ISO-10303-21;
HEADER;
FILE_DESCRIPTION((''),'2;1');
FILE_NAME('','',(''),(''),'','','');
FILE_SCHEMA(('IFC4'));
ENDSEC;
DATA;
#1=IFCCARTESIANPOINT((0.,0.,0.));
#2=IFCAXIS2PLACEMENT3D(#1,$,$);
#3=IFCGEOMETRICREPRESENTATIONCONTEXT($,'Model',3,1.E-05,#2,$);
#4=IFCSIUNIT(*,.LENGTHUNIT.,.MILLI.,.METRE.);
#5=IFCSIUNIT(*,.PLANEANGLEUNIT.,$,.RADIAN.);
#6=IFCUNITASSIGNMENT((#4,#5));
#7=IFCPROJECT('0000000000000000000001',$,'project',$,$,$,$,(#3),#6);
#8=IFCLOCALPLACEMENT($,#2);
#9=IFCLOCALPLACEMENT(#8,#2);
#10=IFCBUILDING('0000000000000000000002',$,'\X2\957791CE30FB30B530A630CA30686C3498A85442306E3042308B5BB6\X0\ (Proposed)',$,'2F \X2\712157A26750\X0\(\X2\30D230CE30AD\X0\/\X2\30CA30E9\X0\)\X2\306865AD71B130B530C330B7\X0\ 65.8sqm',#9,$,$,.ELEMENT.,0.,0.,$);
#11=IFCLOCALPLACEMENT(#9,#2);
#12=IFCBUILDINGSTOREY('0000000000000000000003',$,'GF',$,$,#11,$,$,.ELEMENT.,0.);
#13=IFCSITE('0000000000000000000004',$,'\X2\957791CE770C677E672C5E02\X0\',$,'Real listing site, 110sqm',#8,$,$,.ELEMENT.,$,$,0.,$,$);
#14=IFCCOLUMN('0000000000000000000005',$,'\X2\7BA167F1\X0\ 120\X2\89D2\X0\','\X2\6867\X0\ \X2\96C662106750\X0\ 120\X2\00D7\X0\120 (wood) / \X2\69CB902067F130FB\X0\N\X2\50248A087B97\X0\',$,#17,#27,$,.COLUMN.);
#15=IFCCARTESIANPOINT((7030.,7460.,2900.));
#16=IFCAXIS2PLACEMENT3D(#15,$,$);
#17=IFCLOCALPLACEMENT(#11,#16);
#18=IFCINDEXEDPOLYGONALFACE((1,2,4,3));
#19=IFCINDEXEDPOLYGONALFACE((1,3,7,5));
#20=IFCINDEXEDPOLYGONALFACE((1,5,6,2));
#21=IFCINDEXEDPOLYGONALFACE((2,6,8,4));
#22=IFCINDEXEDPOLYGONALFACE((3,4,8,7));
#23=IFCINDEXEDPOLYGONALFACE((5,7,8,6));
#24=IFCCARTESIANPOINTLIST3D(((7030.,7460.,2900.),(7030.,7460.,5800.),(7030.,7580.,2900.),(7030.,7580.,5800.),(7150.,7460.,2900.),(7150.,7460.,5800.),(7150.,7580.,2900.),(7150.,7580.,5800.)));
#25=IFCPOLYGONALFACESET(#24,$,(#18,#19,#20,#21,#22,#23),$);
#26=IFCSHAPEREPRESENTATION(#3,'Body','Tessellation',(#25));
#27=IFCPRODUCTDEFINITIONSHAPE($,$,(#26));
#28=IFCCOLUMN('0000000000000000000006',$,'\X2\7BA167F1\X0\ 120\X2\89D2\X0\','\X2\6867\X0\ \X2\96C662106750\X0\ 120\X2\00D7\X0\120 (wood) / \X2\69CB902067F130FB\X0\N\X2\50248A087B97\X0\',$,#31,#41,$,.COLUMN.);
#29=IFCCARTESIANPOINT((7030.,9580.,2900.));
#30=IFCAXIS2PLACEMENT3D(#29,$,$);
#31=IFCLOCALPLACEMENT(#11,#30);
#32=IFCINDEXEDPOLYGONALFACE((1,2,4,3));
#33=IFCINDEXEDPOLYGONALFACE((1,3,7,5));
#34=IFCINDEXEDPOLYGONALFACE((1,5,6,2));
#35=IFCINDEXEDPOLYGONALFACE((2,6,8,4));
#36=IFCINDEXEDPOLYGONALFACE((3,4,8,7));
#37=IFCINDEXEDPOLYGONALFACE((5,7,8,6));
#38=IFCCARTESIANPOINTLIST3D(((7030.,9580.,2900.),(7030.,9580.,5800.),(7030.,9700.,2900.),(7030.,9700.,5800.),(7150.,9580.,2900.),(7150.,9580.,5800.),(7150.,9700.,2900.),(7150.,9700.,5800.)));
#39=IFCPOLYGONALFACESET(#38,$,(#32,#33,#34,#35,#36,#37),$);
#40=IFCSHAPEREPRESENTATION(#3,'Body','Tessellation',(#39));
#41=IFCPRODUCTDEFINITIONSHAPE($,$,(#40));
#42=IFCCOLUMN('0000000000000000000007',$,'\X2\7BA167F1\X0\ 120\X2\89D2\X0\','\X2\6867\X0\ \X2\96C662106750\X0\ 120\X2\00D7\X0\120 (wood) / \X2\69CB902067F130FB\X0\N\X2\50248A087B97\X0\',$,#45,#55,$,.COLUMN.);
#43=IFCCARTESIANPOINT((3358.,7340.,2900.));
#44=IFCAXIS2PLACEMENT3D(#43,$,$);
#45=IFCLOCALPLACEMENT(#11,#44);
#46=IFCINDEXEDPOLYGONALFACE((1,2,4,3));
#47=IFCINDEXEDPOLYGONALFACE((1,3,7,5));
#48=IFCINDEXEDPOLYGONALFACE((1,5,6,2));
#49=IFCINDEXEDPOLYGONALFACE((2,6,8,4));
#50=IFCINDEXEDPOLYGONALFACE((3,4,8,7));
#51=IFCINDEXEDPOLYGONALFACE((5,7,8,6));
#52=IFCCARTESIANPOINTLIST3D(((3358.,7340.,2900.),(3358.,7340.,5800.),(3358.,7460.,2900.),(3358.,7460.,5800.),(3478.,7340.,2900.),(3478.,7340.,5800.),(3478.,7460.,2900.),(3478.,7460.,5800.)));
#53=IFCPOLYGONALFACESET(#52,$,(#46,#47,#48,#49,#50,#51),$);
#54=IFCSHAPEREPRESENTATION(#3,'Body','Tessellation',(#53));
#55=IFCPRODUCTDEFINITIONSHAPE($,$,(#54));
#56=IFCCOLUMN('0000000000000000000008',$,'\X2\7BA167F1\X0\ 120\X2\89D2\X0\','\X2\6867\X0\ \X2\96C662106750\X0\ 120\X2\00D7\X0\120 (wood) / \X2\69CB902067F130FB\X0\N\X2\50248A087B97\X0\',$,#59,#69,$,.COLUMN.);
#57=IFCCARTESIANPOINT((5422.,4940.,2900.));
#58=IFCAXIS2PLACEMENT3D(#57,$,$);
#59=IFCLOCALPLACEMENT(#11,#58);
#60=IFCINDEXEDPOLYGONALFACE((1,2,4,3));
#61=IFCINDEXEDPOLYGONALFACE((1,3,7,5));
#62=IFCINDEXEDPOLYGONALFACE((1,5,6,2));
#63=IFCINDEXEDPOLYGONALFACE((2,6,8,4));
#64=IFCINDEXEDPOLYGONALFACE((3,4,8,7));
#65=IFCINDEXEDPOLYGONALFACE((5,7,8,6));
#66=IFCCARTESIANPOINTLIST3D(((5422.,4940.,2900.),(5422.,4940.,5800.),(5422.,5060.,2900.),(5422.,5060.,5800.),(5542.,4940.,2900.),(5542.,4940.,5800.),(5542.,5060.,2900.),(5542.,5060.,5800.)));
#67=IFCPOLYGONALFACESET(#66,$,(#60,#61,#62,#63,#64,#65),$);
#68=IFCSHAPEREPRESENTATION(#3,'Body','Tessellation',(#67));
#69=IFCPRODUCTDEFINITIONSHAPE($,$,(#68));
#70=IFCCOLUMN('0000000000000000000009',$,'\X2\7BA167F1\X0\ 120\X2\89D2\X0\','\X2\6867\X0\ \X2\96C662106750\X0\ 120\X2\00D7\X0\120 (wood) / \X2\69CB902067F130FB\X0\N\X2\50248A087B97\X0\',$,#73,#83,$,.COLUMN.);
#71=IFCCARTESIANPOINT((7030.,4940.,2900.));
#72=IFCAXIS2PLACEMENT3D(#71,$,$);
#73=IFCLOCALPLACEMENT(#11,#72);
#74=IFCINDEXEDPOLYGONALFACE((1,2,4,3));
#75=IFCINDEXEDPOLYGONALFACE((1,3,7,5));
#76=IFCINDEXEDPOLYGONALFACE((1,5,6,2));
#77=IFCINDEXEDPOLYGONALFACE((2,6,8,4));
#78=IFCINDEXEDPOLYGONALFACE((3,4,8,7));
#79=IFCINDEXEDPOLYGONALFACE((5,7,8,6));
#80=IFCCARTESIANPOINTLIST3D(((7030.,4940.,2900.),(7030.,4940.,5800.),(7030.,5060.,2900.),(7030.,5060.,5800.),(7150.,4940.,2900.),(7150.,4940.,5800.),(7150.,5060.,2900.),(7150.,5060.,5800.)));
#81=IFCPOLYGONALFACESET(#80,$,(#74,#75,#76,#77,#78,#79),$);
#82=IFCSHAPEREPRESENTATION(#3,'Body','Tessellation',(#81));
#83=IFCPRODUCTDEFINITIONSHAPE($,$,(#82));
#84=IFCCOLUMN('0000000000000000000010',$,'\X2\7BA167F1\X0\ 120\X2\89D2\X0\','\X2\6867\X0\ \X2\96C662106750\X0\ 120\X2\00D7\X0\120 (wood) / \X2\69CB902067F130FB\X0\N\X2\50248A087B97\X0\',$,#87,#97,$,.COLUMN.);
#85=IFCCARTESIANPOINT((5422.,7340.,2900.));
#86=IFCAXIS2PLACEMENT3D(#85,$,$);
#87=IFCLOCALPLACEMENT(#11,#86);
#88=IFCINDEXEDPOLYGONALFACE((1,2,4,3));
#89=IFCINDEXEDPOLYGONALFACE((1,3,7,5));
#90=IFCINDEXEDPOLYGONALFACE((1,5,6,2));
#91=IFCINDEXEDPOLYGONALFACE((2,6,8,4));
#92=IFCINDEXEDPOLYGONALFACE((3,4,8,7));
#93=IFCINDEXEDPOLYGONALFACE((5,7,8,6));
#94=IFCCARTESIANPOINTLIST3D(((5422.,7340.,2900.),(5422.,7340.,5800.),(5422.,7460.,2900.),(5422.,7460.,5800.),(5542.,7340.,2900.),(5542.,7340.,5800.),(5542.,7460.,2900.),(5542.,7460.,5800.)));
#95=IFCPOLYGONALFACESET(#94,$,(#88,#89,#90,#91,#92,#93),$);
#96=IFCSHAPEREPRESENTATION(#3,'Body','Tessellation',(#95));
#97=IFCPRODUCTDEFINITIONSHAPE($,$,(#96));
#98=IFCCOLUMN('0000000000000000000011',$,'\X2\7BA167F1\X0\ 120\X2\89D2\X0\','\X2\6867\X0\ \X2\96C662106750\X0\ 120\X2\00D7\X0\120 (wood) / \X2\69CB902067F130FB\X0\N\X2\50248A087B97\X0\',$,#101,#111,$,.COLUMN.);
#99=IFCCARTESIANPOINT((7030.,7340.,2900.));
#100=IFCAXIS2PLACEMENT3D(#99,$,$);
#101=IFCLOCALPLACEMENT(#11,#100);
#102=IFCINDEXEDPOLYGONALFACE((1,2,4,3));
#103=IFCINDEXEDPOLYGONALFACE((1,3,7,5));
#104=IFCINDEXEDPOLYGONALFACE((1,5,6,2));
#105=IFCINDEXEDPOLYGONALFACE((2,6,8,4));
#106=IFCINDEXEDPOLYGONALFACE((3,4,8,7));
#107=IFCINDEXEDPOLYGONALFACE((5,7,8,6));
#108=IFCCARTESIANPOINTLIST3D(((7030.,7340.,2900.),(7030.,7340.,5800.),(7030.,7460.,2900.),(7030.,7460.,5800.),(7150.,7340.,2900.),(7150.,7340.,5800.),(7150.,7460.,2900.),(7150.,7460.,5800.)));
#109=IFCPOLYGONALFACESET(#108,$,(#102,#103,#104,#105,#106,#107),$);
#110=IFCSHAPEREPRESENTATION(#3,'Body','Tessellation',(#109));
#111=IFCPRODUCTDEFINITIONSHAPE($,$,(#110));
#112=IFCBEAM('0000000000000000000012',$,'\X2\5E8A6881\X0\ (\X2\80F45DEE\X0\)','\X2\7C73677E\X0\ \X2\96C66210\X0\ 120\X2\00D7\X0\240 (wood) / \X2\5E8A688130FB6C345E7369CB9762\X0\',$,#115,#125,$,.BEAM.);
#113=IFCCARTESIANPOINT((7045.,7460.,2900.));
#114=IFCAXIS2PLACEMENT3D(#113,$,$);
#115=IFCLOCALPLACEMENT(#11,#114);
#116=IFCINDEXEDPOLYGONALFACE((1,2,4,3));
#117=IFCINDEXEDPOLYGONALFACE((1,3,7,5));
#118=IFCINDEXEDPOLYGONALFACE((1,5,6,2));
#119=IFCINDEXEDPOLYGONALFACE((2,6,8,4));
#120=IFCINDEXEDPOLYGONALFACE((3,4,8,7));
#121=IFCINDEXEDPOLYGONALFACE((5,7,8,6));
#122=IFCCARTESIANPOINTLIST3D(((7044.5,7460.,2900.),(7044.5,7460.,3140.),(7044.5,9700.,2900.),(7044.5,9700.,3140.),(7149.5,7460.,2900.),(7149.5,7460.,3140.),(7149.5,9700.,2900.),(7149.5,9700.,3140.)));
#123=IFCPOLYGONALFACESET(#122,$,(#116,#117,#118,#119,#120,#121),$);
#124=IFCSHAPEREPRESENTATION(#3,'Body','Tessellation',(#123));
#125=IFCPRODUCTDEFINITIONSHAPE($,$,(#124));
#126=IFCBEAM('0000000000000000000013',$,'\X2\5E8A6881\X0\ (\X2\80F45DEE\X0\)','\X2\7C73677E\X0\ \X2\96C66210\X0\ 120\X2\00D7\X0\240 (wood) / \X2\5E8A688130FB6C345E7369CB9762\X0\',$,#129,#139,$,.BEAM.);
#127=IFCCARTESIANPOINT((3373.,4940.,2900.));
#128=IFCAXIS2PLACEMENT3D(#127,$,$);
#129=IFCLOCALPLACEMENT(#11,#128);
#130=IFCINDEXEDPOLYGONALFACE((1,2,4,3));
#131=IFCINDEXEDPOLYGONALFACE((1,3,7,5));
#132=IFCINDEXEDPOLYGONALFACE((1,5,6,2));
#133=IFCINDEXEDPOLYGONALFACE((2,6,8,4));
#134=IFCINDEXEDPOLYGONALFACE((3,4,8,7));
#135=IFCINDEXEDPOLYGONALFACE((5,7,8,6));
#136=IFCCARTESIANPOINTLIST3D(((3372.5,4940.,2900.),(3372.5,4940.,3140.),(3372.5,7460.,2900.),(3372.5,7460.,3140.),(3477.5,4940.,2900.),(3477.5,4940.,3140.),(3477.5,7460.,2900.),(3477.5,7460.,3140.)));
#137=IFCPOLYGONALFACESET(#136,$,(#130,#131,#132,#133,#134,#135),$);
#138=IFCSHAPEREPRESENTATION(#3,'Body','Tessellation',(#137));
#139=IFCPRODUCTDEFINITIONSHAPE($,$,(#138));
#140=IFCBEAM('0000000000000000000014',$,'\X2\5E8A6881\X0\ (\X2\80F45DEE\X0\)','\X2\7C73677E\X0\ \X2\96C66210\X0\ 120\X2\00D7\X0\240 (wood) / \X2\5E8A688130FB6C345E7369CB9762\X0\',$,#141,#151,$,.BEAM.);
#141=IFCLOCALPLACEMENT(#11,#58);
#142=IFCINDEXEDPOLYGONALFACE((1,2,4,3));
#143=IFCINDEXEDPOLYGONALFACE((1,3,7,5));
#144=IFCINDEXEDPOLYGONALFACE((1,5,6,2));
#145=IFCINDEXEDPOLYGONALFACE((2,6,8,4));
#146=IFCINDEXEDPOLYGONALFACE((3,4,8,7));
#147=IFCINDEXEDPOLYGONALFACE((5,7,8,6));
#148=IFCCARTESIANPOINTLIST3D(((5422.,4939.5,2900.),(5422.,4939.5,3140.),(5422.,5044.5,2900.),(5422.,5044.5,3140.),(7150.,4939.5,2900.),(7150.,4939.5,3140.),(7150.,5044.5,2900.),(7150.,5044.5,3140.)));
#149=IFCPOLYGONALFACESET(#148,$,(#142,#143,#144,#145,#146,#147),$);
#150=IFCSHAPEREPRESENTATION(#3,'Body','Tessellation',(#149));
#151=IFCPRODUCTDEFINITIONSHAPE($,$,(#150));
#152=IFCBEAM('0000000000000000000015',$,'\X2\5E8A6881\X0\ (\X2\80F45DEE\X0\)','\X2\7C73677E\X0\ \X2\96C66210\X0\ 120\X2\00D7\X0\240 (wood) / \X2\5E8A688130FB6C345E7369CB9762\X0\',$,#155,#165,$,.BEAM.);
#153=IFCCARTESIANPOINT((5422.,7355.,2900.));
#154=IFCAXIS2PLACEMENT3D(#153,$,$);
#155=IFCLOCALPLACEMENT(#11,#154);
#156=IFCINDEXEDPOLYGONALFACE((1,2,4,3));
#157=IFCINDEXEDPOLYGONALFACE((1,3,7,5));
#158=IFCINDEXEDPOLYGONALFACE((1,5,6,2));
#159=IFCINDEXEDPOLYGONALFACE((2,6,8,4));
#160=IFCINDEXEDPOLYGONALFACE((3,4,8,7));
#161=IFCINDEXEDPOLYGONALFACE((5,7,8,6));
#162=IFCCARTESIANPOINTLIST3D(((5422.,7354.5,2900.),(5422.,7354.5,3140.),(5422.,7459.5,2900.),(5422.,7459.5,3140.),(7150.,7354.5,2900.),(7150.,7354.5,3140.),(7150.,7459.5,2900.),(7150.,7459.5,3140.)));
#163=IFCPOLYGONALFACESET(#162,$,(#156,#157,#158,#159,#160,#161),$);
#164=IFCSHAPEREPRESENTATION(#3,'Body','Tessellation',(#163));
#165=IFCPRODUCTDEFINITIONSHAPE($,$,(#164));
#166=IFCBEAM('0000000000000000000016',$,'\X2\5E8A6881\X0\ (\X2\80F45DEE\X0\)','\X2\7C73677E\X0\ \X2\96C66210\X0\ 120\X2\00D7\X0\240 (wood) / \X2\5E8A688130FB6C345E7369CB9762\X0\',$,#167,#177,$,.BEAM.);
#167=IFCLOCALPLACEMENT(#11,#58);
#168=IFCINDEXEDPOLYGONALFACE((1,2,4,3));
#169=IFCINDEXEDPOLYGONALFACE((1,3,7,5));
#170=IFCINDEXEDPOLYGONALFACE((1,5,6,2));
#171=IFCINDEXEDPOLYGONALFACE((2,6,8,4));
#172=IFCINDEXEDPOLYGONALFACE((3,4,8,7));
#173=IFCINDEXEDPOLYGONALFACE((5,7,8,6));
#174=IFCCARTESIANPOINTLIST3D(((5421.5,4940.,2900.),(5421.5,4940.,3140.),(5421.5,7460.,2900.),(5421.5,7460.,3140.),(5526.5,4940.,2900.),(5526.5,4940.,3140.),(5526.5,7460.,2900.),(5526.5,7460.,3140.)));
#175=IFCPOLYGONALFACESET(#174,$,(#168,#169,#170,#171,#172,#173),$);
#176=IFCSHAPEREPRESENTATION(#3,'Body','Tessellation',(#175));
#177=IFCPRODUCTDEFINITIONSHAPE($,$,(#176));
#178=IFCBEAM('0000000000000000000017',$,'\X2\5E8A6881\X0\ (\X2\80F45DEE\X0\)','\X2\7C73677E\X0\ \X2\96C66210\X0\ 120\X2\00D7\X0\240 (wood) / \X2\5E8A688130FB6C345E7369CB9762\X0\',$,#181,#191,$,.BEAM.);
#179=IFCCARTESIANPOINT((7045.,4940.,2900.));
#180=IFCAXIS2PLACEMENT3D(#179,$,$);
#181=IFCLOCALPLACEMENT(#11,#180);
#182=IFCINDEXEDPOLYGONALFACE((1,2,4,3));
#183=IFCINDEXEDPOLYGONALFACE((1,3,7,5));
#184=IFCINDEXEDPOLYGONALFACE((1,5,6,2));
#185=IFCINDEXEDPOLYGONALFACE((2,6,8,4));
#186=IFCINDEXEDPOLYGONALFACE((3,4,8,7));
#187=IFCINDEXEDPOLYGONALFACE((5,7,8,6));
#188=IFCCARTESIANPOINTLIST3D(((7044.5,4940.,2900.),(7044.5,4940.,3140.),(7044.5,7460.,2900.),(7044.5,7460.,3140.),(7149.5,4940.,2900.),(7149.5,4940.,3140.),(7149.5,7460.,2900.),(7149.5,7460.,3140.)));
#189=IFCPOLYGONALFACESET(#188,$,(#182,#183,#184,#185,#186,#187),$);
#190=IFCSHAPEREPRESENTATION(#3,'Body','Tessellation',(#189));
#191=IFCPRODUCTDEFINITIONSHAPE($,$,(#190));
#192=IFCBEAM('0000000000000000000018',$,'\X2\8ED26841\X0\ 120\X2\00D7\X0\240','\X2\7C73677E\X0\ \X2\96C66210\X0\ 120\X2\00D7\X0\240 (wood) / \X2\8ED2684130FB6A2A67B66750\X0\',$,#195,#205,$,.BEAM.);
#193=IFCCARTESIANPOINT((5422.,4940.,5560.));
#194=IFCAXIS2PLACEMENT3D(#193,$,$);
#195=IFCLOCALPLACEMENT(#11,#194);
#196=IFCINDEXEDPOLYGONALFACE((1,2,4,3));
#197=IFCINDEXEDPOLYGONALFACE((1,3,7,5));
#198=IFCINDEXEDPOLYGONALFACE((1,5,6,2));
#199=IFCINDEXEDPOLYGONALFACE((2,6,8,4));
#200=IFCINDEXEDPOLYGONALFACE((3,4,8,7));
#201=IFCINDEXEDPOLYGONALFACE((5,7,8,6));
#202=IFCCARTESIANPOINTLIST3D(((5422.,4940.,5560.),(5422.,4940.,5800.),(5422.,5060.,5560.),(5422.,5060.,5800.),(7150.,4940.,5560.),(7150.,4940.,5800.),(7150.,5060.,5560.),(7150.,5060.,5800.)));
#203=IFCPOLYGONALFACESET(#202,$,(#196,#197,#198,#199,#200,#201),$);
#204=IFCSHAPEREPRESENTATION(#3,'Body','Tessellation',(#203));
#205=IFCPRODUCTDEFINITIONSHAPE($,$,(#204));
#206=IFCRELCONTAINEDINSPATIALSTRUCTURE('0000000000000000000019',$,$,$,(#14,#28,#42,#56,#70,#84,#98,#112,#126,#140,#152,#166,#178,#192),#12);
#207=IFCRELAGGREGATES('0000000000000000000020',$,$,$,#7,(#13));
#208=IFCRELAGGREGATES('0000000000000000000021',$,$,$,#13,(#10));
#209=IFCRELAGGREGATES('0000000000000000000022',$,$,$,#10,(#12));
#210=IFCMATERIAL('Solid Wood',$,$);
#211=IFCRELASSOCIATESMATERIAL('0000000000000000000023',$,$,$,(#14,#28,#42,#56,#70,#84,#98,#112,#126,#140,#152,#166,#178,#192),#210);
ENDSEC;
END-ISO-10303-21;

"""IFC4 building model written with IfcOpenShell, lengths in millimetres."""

from ifc_helpers import new_model, si_unit, frame, frame_2d, origin, place, context, project, spatial, rectangle, extrude, material, element, save


model = new_model("IFC4")

# Units and contexts
model_context = context("Model", 3, precision=1e-05, world=origin())
ifc_project = project(units=[si_unit("LENGTHUNIT", "METRE", prefix="MILLI"), si_unit("PLANEANGLEUNIT", "RADIAN")], contexts=[model_context])

# Site, building, storey
site_placement = place(None, origin())
site = spatial("IfcSite", under=ifc_project, at=site_placement, Name="長野県松本市", ObjectType="Real listing site, 110sqm", CompositionType="ELEMENT", RefElevation=0.0)
building_placement = place(site_placement, origin())
building = spatial("IfcBuilding", under=site, at=building_placement, Name="長野・サウナと水風呂のある家 (Proposed)", ObjectType="2F 無垢材(ヒノキ/ナラ)と断熱サッシ 65.8sqm", CompositionType="ELEMENT", ElevationOfRefHeight=0.0, ElevationOfTerrain=0.0)
storey_placement = place(building_placement, origin())
storey = spatial("IfcBuildingStorey", under=building, at=storey_placement, Name="GF", CompositionType="ELEMENT", Elevation=0.0)

# Columns
ifc_material_1 = material(Name="Solid Wood")
column_1_placement = place(storey_placement, frame((7030.0, 7460.0, 2900.0)))
element("IfcColumn", 1, at=column_1_placement, inside=storey, material=ifc_material_1, Name="管柱 120角", Description="桧 集成材 120×120 (wood) / 構造柱・N値計算", PredefinedType="COLUMN", context=model_context, shape_type="SweptSolid", body=[
    extrude(rectangle(XDim=120.0, YDim=120.0, at=frame_2d((60.0, 60.0))), frame((7030.0, 7460.0, 2900.0)), (0.0, 0.0, 1.0), 2900.0),
])
column_2_placement = place(storey_placement, frame((7030.0, 9580.0, 2900.0)))
element("IfcColumn", 2, at=column_2_placement, inside=storey, material=ifc_material_1, Name="管柱 120角", Description="桧 集成材 120×120 (wood) / 構造柱・N値計算", PredefinedType="COLUMN", context=model_context, shape_type="SweptSolid", body=[
    extrude(rectangle(XDim=120.0, YDim=120.0, at=frame_2d((60.0, 60.0))), frame((7030.0, 9580.0, 2900.0)), (0.0, 0.0, 1.0), 2900.0),
])
column_3_placement = place(storey_placement, frame((3358.0, 7340.0, 2900.0)))
element("IfcColumn", 3, at=column_3_placement, inside=storey, material=ifc_material_1, Name="管柱 120角", Description="桧 集成材 120×120 (wood) / 構造柱・N値計算", PredefinedType="COLUMN", context=model_context, shape_type="SweptSolid", body=[
    extrude(rectangle(XDim=120.0, YDim=120.0, at=frame_2d((60.0, 60.0))), frame((3358.0, 7340.0, 2900.0)), (0.0, 0.0, 1.0), 2900.0),
])
column_4_placement = place(storey_placement, frame((5422.0, 4940.0, 2900.0)))
element("IfcColumn", 4, at=column_4_placement, inside=storey, material=ifc_material_1, Name="管柱 120角", Description="桧 集成材 120×120 (wood) / 構造柱・N値計算", PredefinedType="COLUMN", context=model_context, shape_type="SweptSolid", body=[
    extrude(rectangle(XDim=120.0, YDim=120.0, at=frame_2d((60.0, 60.0))), frame((5422.0, 4940.0, 2900.0)), (0.0, 0.0, 1.0), 2900.0),
])
column_5_placement = place(storey_placement, frame((7030.0, 4940.0, 2900.0)))
element("IfcColumn", 5, at=column_5_placement, inside=storey, material=ifc_material_1, Name="管柱 120角", Description="桧 集成材 120×120 (wood) / 構造柱・N値計算", PredefinedType="COLUMN", context=model_context, shape_type="SweptSolid", body=[
    extrude(rectangle(XDim=120.0, YDim=120.0, at=frame_2d((60.0, 60.0))), frame((7030.0, 4940.0, 2900.0)), (0.0, 0.0, 1.0), 2900.0),
])
column_6_placement = place(storey_placement, frame((5422.0, 7340.0, 2900.0)))
element("IfcColumn", 6, at=column_6_placement, inside=storey, material=ifc_material_1, Name="管柱 120角", Description="桧 集成材 120×120 (wood) / 構造柱・N値計算", PredefinedType="COLUMN", context=model_context, shape_type="SweptSolid", body=[
    extrude(rectangle(XDim=120.0, YDim=120.0, at=frame_2d((60.0, 60.0))), frame((5422.0, 7340.0, 2900.0)), (0.0, 0.0, 1.0), 2900.0),
])
column_7_placement = place(storey_placement, frame((7030.0, 7340.0, 2900.0)))
element("IfcColumn", 7, at=column_7_placement, inside=storey, material=ifc_material_1, Name="管柱 120角", Description="桧 集成材 120×120 (wood) / 構造柱・N値計算", PredefinedType="COLUMN", context=model_context, shape_type="SweptSolid", body=[
    extrude(rectangle(XDim=120.0, YDim=120.0, at=frame_2d((60.0, 60.0))), frame((7030.0, 7340.0, 2900.0)), (0.0, 0.0, 1.0), 2900.0),
])

# Beams
beam_1_placement = place(storey_placement, frame((7045.0, 7460.0, 2900.0)))
element("IfcBeam", 8, at=beam_1_placement, inside=storey, material=ifc_material_1, Name="床梁 (胴差)", Description="米松 集成 120×240 (wood) / 床梁・水平構面", PredefinedType="BEAM", context=model_context, shape_type="SweptSolid", body=[
    extrude(rectangle(XDim=105.0, YDim=2240.0, at=frame_2d((52.0, 1120.0))), frame((7045.0, 7460.0, 2900.0)), (0.0, 0.0, 1.0), 240.0),
])
beam_2_placement = place(storey_placement, frame((3373.0, 4940.0, 2900.0)))
element("IfcBeam", 9, at=beam_2_placement, inside=storey, material=ifc_material_1, Name="床梁 (胴差)", Description="米松 集成 120×240 (wood) / 床梁・水平構面", PredefinedType="BEAM", context=model_context, shape_type="SweptSolid", body=[
    extrude(rectangle(XDim=105.0, YDim=2520.0, at=frame_2d((52.0, 1260.0))), frame((3373.0, 4940.0, 2900.0)), (0.0, 0.0, 1.0), 240.0),
])
beam_3_placement = place(storey_placement, frame((5422.0, 4940.0, 2900.0)))
element("IfcBeam", 10, at=beam_3_placement, inside=storey, material=ifc_material_1, Name="床梁 (胴差)", Description="米松 集成 120×240 (wood) / 床梁・水平構面", PredefinedType="BEAM", context=model_context, shape_type="SweptSolid", body=[
    extrude(rectangle(XDim=1728.0, YDim=105.0, at=frame_2d((864.0, 52.0))), frame((5422.0, 4940.0, 2900.0)), (0.0, 0.0, 1.0), 240.0),
])
beam_4_placement = place(storey_placement, frame((5422.0, 7355.0, 2900.0)))
element("IfcBeam", 11, at=beam_4_placement, inside=storey, material=ifc_material_1, Name="床梁 (胴差)", Description="米松 集成 120×240 (wood) / 床梁・水平構面", PredefinedType="BEAM", context=model_context, shape_type="SweptSolid", body=[
    extrude(rectangle(XDim=1728.0, YDim=105.0, at=frame_2d((864.0, 52.0))), frame((5422.0, 7355.0, 2900.0)), (0.0, 0.0, 1.0), 240.0),
])
beam_5_placement = place(storey_placement, frame((5422.0, 4940.0, 2900.0)))
element("IfcBeam", 12, at=beam_5_placement, inside=storey, material=ifc_material_1, Name="床梁 (胴差)", Description="米松 集成 120×240 (wood) / 床梁・水平構面", PredefinedType="BEAM", context=model_context, shape_type="SweptSolid", body=[
    extrude(rectangle(XDim=105.0, YDim=2520.0, at=frame_2d((52.0, 1260.0))), frame((5422.0, 4940.0, 2900.0)), (0.0, 0.0, 1.0), 240.0),
])
beam_6_placement = place(storey_placement, frame((7045.0, 4940.0, 2900.0)))
element("IfcBeam", 13, at=beam_6_placement, inside=storey, material=ifc_material_1, Name="床梁 (胴差)", Description="米松 集成 120×240 (wood) / 床梁・水平構面", PredefinedType="BEAM", context=model_context, shape_type="SweptSolid", body=[
    extrude(rectangle(XDim=105.0, YDim=2520.0, at=frame_2d((52.0, 1260.0))), frame((7045.0, 4940.0, 2900.0)), (0.0, 0.0, 1.0), 240.0),
])
beam_7_placement = place(storey_placement, frame((5422.0, 4940.0, 5560.0)))
element("IfcBeam", 14, at=beam_7_placement, inside=storey, material=ifc_material_1, Name="軒桁 120×240", Description="米松 集成 120×240 (wood) / 軒桁・横架材", PredefinedType="BEAM", context=model_context, shape_type="SweptSolid", body=[
    extrude(rectangle(XDim=1728.0, YDim=120.0, at=frame_2d((864.0, 60.0))), frame((5422.0, 4940.0, 5560.0)), (0.0, 0.0, 1.0), 240.0),
])

save(model, "model.ifc")
